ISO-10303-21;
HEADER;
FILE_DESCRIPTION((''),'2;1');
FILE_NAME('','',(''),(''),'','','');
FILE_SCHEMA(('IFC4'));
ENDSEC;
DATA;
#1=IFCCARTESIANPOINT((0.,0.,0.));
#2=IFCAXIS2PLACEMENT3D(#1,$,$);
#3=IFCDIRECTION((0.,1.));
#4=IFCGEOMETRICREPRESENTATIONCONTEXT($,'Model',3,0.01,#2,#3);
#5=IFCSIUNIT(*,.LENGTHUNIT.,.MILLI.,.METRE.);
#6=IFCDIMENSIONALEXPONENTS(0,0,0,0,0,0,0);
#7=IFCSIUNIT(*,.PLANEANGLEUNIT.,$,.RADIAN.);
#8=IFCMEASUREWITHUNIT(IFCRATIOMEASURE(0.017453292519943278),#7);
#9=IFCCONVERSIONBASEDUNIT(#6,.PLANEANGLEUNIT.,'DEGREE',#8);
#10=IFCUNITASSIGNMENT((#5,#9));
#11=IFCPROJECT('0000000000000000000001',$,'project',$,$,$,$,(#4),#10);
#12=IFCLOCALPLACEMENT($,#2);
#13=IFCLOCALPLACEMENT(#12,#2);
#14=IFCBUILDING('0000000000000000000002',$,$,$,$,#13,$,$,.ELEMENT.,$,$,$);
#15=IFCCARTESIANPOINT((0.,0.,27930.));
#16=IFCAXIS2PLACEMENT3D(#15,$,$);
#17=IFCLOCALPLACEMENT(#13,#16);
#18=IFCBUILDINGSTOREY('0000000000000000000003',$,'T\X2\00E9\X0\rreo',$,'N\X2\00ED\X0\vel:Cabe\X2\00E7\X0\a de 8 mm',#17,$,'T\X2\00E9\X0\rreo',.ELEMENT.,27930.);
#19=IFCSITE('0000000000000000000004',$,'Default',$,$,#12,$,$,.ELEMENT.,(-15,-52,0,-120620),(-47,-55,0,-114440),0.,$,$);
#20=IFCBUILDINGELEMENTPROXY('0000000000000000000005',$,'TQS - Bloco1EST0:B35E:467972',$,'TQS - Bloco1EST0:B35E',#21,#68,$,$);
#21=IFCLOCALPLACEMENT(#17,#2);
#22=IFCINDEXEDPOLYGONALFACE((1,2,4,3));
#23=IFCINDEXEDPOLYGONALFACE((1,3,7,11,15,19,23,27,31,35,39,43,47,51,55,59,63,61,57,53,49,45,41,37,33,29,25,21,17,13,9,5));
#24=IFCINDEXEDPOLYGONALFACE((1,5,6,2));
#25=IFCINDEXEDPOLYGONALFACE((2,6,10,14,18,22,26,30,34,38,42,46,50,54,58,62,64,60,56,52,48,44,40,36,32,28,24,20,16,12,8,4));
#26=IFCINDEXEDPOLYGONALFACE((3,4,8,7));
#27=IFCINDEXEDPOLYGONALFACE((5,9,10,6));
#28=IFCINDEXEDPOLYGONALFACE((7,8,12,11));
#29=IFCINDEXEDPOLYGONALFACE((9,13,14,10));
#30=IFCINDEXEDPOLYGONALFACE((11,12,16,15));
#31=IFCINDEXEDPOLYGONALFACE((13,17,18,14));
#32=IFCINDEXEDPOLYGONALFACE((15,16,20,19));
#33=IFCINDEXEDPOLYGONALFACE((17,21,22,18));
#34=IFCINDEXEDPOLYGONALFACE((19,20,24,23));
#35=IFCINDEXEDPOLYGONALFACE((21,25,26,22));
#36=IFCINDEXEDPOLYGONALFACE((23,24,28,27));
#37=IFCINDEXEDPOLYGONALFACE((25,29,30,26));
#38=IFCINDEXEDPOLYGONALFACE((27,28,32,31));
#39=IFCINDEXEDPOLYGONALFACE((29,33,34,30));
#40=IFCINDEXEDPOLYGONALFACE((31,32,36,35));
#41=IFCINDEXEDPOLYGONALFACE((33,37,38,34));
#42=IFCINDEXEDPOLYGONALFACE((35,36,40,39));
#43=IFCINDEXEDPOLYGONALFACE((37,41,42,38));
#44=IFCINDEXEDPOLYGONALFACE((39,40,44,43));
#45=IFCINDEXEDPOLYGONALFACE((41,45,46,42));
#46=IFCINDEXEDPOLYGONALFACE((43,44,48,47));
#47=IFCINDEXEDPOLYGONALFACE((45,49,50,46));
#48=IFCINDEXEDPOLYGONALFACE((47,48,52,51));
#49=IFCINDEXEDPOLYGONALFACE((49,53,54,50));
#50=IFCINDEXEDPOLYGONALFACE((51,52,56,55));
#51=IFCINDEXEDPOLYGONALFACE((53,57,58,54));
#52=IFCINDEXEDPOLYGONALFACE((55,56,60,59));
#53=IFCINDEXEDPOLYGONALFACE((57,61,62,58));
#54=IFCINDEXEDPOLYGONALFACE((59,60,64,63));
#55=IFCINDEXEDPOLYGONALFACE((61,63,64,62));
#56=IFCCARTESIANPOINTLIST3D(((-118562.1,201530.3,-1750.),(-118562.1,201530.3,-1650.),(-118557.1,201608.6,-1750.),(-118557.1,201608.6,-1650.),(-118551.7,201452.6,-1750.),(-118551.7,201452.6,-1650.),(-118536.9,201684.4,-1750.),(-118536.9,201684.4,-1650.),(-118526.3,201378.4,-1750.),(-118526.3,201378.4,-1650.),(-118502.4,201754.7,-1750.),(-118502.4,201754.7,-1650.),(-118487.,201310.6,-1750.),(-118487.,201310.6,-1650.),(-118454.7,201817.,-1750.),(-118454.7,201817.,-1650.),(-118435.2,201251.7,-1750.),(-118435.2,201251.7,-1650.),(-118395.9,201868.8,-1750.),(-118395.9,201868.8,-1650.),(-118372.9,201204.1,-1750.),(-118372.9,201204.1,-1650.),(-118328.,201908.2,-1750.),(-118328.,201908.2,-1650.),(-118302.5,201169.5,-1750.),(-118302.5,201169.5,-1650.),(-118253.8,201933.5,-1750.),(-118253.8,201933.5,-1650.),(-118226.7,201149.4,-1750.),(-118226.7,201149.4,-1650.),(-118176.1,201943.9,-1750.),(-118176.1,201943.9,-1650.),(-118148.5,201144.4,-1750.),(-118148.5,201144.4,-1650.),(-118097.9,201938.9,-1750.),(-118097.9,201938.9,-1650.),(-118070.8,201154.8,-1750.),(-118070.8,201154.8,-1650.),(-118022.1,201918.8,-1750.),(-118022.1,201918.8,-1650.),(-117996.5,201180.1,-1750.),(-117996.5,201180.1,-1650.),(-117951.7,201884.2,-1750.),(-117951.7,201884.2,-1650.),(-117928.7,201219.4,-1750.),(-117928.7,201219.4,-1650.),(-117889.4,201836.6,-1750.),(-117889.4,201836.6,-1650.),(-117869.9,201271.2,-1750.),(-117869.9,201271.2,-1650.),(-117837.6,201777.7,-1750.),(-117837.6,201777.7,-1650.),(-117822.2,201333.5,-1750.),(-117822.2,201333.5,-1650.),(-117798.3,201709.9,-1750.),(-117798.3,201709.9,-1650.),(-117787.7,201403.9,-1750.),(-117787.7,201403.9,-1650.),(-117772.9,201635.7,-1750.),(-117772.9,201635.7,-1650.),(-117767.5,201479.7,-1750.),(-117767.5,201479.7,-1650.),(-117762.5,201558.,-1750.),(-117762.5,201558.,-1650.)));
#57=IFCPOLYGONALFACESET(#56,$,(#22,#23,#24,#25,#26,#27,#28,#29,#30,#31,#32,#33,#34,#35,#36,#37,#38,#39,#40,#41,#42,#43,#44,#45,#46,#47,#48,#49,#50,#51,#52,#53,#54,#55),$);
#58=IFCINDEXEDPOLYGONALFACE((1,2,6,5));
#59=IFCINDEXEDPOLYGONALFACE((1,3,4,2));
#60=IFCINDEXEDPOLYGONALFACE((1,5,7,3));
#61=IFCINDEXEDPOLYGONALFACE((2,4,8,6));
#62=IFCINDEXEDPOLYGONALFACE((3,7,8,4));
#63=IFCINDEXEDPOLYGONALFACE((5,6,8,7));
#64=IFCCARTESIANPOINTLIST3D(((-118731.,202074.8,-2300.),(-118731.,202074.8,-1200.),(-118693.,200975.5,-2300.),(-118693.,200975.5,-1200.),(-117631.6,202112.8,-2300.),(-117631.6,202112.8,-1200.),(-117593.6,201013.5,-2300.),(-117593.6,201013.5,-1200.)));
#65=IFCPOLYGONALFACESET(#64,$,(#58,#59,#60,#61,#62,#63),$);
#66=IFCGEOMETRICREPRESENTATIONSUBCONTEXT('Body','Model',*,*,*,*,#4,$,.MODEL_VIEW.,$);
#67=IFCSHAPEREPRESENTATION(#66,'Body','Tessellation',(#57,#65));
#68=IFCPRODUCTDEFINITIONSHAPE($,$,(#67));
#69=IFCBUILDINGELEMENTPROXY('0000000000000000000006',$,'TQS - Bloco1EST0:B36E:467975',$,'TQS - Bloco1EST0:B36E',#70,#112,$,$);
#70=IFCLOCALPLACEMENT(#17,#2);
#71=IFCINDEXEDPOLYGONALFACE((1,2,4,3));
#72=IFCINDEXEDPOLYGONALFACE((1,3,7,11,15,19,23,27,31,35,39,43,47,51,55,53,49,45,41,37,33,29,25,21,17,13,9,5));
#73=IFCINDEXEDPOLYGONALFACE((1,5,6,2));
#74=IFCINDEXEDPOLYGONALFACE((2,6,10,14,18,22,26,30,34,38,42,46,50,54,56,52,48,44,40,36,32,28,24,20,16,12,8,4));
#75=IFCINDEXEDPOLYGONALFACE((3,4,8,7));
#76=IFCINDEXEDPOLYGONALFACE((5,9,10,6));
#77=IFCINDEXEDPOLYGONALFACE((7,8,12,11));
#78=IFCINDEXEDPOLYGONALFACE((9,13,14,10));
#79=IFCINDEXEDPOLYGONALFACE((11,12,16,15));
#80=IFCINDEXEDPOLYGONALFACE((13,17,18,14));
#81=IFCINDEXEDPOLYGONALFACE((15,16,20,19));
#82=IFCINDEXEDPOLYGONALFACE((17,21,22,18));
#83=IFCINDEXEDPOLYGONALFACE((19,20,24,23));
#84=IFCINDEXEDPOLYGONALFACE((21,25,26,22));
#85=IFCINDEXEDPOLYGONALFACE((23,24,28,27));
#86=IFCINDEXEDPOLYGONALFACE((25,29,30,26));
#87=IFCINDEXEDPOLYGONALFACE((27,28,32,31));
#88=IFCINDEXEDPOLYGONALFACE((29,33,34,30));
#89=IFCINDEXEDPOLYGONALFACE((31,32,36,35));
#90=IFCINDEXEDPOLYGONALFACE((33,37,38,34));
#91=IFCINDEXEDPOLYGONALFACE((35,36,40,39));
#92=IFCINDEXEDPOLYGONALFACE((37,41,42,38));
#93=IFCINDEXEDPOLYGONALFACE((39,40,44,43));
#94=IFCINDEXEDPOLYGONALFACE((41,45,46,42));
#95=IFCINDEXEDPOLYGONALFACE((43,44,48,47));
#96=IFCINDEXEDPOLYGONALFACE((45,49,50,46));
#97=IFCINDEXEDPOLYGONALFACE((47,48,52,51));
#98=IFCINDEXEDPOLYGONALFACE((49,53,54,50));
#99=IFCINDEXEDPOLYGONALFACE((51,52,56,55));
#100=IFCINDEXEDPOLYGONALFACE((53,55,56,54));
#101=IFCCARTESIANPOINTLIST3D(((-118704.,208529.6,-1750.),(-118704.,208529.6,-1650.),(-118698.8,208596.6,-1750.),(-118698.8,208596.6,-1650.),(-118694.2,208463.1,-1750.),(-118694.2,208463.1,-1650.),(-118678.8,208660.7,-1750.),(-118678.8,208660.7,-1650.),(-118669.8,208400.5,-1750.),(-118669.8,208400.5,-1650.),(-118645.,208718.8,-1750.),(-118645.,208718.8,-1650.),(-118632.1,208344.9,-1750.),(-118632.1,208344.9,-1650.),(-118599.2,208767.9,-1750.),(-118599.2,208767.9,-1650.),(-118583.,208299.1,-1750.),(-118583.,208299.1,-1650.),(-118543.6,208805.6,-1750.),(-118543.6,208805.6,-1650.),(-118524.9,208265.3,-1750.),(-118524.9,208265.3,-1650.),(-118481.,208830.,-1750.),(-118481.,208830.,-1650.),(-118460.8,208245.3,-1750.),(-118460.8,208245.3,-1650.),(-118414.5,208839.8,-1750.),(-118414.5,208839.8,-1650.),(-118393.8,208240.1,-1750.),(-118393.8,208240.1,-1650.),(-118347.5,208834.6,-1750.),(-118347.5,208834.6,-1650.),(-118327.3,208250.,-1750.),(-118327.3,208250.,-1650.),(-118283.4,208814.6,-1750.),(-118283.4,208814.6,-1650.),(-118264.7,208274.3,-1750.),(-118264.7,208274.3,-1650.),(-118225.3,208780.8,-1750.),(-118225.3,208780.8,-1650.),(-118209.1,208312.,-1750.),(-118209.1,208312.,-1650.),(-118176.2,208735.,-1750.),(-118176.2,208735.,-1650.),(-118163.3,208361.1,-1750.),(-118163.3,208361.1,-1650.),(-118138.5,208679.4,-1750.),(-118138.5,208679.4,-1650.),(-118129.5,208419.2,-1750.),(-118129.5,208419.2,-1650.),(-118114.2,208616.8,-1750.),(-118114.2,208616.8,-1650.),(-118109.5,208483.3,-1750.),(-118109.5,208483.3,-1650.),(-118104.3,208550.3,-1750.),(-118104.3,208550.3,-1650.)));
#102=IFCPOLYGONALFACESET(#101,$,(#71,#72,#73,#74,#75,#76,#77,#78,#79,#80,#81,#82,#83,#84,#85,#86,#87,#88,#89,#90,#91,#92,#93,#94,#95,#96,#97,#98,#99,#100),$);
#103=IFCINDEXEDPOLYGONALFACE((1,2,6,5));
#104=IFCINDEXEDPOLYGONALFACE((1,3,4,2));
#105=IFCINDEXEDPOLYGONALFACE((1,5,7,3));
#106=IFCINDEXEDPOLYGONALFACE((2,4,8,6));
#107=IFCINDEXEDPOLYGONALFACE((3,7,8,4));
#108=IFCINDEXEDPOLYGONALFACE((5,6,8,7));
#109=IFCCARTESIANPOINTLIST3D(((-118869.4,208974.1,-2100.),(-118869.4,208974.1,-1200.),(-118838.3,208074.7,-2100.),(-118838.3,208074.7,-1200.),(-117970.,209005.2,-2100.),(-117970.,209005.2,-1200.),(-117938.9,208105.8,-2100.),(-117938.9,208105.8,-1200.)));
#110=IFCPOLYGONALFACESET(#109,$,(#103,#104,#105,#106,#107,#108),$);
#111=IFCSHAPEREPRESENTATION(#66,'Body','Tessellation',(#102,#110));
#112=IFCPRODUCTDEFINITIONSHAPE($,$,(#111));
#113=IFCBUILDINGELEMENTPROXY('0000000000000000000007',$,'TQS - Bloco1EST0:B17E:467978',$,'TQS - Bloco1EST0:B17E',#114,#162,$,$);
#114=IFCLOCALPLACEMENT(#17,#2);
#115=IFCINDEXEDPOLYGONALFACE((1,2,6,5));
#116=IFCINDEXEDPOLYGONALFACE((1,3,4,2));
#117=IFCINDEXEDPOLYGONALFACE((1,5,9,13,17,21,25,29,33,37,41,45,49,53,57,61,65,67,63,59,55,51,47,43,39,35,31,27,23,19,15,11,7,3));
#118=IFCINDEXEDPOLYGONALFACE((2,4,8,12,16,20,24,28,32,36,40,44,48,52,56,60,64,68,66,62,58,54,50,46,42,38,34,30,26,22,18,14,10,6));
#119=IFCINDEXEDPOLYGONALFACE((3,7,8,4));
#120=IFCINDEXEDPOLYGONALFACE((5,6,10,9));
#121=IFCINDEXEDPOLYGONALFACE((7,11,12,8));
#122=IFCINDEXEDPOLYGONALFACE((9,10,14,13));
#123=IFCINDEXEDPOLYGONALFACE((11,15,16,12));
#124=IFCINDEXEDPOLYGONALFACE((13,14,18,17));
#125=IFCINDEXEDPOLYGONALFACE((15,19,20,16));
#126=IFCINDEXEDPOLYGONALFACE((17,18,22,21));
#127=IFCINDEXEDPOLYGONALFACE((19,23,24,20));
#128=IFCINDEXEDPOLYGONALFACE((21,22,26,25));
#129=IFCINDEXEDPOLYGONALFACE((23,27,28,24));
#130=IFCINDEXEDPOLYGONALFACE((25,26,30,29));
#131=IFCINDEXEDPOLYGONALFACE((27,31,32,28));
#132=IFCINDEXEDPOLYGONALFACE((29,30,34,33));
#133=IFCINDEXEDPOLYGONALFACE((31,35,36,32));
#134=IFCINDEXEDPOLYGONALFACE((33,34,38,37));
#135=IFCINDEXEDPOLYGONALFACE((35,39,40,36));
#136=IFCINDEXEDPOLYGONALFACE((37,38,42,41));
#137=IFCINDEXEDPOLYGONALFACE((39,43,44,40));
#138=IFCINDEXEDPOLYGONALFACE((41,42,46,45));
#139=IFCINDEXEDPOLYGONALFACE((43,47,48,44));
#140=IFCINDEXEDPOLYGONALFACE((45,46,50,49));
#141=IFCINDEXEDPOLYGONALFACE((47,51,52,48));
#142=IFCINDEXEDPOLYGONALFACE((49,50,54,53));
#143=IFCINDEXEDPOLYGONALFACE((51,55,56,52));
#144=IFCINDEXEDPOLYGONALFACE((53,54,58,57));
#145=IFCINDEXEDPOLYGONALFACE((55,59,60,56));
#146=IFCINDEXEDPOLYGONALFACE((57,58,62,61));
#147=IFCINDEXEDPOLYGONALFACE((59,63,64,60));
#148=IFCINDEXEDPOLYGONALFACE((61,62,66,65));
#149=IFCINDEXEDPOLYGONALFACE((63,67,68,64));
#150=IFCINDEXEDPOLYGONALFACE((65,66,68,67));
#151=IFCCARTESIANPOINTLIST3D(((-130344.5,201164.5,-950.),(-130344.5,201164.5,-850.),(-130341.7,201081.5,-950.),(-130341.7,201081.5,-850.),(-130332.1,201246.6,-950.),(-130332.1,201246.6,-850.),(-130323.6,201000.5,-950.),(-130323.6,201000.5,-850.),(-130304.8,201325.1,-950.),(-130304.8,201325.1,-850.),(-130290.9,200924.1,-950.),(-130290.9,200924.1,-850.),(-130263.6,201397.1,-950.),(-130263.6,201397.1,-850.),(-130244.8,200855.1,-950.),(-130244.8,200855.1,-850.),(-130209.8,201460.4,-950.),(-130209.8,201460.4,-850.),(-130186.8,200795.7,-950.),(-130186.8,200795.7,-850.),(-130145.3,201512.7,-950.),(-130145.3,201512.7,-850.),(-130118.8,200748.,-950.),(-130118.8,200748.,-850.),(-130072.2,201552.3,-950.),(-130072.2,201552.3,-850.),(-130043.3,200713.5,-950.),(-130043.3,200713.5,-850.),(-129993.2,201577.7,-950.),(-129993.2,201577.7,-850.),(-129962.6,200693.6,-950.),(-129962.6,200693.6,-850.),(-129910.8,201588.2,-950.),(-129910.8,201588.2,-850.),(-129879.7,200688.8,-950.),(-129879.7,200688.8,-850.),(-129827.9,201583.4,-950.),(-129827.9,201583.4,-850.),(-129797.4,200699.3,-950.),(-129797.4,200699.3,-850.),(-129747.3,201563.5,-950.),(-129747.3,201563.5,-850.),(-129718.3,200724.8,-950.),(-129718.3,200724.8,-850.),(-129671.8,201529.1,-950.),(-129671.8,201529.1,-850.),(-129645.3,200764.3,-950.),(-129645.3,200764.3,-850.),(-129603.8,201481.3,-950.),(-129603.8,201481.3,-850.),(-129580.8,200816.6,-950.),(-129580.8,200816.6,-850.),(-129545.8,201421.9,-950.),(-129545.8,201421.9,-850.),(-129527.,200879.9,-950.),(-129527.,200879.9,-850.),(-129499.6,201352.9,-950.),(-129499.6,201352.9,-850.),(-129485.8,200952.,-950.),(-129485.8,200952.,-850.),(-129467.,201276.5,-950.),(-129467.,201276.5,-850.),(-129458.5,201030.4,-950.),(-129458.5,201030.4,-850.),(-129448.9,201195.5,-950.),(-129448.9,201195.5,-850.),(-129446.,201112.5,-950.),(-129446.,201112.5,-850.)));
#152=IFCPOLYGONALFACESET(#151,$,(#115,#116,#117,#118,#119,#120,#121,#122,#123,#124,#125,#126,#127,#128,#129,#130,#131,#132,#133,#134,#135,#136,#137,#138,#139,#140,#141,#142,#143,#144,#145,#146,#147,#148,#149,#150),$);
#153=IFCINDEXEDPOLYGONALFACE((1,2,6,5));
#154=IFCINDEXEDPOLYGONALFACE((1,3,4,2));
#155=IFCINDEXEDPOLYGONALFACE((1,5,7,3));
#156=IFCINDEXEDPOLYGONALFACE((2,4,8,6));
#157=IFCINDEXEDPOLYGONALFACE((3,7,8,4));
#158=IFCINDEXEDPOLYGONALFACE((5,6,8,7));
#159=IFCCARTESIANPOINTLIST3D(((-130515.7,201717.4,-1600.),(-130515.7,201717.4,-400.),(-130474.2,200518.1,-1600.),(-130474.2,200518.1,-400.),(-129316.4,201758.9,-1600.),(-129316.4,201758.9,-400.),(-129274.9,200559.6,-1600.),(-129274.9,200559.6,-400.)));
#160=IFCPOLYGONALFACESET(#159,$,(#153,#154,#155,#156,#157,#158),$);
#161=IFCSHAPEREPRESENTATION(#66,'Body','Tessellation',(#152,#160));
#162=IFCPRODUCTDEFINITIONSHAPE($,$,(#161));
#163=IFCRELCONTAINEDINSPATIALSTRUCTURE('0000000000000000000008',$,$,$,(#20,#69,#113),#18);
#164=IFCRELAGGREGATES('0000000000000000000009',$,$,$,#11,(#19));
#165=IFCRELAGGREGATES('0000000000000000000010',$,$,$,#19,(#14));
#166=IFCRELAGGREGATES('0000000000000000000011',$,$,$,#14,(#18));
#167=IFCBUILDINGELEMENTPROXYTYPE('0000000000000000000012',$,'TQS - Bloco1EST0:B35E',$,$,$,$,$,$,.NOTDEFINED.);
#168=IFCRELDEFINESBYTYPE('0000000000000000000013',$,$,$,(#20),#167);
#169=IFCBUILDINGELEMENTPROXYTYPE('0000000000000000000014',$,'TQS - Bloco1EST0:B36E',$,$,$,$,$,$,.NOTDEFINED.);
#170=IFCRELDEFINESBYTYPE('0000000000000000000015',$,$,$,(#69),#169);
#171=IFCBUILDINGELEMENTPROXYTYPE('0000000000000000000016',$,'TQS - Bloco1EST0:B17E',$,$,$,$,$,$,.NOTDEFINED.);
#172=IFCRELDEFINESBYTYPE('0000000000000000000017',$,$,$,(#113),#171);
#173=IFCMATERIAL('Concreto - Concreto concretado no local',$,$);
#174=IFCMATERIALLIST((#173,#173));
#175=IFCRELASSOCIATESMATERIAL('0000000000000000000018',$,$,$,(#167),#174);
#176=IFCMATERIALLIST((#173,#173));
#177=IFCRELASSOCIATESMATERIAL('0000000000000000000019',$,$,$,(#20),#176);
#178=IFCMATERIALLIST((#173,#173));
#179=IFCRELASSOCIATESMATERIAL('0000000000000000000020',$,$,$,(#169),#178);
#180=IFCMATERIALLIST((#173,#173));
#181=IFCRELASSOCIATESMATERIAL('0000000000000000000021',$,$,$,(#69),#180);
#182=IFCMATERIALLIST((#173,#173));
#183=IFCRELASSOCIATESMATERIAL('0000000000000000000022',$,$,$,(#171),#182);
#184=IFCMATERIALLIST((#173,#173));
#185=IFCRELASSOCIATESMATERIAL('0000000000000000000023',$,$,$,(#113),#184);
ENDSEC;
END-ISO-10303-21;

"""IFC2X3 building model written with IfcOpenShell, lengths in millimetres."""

from ifc_helpers import new_model, entity, si_unit, converted_unit, direction, frame, frame_2d, origin, origin_2d_with_axis, place, context, subcontext, project, spatial, rectangle, circle, extrude, source, transform, mapped, material, material_list, type_object, type_shapes, element, save


model = new_model("IFC2X3")

# Units and contexts
model_context = context("Model", 3, precision=0.01, world=origin(), true_north=direction((0.0, 1.0)))
body_context = subcontext(model_context, "Body", "Model", "MODEL_VIEW")
ifc_project = project(units=[si_unit("LENGTHUNIT", "METRE", prefix="MILLI"), converted_unit("PLANEANGLEUNIT", "DEGREE", entity("IfcRatioMeasure", 0.017453292519943278), si_unit("PLANEANGLEUNIT", "RADIAN"), dimensions=[0, 0, 0, 0, 0, 0, 0])], contexts=[model_context])

# Site, building, storey
site_placement = place(None, origin())
site = spatial("IfcSite", under=ifc_project, at=site_placement, Name="Default", CompositionType="ELEMENT", RefLatitude=(-15, -52, 0, -120620), RefLongitude=(-47, -55, 0, -114440), RefElevation=0.0)
building_placement = place(site_placement, origin())
building = spatial("IfcBuilding", under=site, at=building_placement, CompositionType="ELEMENT")
storey_placement = place(building_placement, frame((0.0, 0.0, 27930.0)))
storey = spatial("IfcBuildingStorey", under=building, at=storey_placement, Name="Térreo", ObjectType="Nível:Cabeça de 8 mm", LongName="Térreo", CompositionType="ELEMENT", Elevation=27930.0)

# Building element proxies
ifc_material_1 = material(Name="Concreto - Concreto concretado no local")
ifc_material_list_1 = material_list([ifc_material_1, ifc_material_1])
ifc_material_list_2 = material_list([ifc_material_1, ifc_material_1])
building_element_proxy_type_1 = type_object("IfcBuildingElementProxyType", Name="TQS - Bloco1EST0:B35E", PredefinedType="NOTDEFINED", material=ifc_material_list_2)
shared_shape_1 = source(origin(), body_context, "Body", "SweptSolid", [
    extrude(circle(Radius=400.0, at=frame_2d((0.0, 0.0), x_axis=(1.0, 0.0))), frame((0.0, 0.0, -550.0)), (0.0, 0.0, 1.0), 100.0),
    extrude(rectangle(XDim=1100.0, YDim=1100.0, at=origin_2d_with_axis()), frame((0.0, 0.0, -1100.0), z_axis=(0.0, 0.0, 1.0), x_axis=(-1.0, 0.0, 0.0)), (0.0, 0.0, 1.0), 1100.0),
])
type_shapes(building_element_proxy_type_1, [shared_shape_1])
proxy_1_placement = place(storey_placement, frame((-118162.3, 201544.1, -1200.0), z_axis=(0.0, 0.0, 1.0), x_axis=(-0.034551, 0.999403, 0.0)))
element("IfcBuildingElementProxy", 1, at=proxy_1_placement, inside=storey, type_object=building_element_proxy_type_1, material=ifc_material_list_1, Name="TQS - Bloco1EST0:B35E:467972", ObjectType="TQS - Bloco1EST0:B35E", context=body_context, shape_type="MappedRepresentation", body=[
    mapped(shared_shape_1, transform((0.0, 0.0, 0.0), scale=1.0)),
])
ifc_material_list_3 = material_list([ifc_material_1, ifc_material_1])
ifc_material_list_4 = material_list([ifc_material_1, ifc_material_1])
building_element_proxy_type_2 = type_object("IfcBuildingElementProxyType", Name="TQS - Bloco1EST0:B36E", PredefinedType="NOTDEFINED", material=ifc_material_list_4)
shared_shape_2 = source(origin(), body_context, "Body", "SweptSolid", [
    extrude(circle(Radius=300.0, at=frame_2d((0.0, 0.0), x_axis=(1.0, 0.0))), frame((0.0, 0.0, -550.0)), (0.0, 0.0, 1.0), 100.0),
    extrude(rectangle(XDim=900.0, YDim=900.0, at=origin_2d_with_axis()), frame((0.0, 0.0, -900.0), z_axis=(0.0, 0.0, 1.0), x_axis=(-1.0, 0.0, 0.0)), (0.0, 0.0, 1.0), 900.0),
])
type_shapes(building_element_proxy_type_2, [shared_shape_2])
proxy_2_placement = place(storey_placement, frame((-118404.2, 208540.0, -1200.0), z_axis=(0.0, 0.0, 1.0), x_axis=(-0.034551, 0.999403, 0.0)))
element("IfcBuildingElementProxy", 2, at=proxy_2_placement, inside=storey, type_object=building_element_proxy_type_2, material=ifc_material_list_3, Name="TQS - Bloco1EST0:B36E:467975", ObjectType="TQS - Bloco1EST0:B36E", context=body_context, shape_type="MappedRepresentation", body=[
    mapped(shared_shape_2, transform((0.0, 0.0, 0.0), scale=1.0)),
])
ifc_material_list_5 = material_list([ifc_material_1, ifc_material_1])
ifc_material_list_6 = material_list([ifc_material_1, ifc_material_1])
building_element_proxy_type_3 = type_object("IfcBuildingElementProxyType", Name="TQS - Bloco1EST0:B17E", PredefinedType="NOTDEFINED", material=ifc_material_list_6)
shared_shape_3 = source(origin(), body_context, "Body", "SweptSolid", [
    extrude(circle(Radius=450.0, at=frame_2d((0.0, 0.0), x_axis=(1.0, 0.0))), frame((0.0, 0.0, -550.0)), (0.0, 0.0, 1.0), 100.0),
    extrude(rectangle(XDim=1200.0, YDim=1200.0, at=origin_2d_with_axis()), frame((0.0, 0.0, -1200.0), z_axis=(0.0, 0.0, 1.0), x_axis=(-1.0, 0.0, 0.0)), (0.0, 0.0, 1.0), 1200.0),
])
type_shapes(building_element_proxy_type_3, [shared_shape_3])
proxy_3_placement = place(storey_placement, frame((-129895.3, 201138.5, -400.0), z_axis=(0.0, 0.0, 1.0), x_axis=(-0.034551, 0.999403, 0.0)))
element("IfcBuildingElementProxy", 3, at=proxy_3_placement, inside=storey, type_object=building_element_proxy_type_3, material=ifc_material_list_5, Name="TQS - Bloco1EST0:B17E:467978", ObjectType="TQS - Bloco1EST0:B17E", context=body_context, shape_type="MappedRepresentation", body=[
    mapped(shared_shape_3, transform((0.0, 0.0, 0.0), scale=1.0)),
])

save(model, "model.ifc")
